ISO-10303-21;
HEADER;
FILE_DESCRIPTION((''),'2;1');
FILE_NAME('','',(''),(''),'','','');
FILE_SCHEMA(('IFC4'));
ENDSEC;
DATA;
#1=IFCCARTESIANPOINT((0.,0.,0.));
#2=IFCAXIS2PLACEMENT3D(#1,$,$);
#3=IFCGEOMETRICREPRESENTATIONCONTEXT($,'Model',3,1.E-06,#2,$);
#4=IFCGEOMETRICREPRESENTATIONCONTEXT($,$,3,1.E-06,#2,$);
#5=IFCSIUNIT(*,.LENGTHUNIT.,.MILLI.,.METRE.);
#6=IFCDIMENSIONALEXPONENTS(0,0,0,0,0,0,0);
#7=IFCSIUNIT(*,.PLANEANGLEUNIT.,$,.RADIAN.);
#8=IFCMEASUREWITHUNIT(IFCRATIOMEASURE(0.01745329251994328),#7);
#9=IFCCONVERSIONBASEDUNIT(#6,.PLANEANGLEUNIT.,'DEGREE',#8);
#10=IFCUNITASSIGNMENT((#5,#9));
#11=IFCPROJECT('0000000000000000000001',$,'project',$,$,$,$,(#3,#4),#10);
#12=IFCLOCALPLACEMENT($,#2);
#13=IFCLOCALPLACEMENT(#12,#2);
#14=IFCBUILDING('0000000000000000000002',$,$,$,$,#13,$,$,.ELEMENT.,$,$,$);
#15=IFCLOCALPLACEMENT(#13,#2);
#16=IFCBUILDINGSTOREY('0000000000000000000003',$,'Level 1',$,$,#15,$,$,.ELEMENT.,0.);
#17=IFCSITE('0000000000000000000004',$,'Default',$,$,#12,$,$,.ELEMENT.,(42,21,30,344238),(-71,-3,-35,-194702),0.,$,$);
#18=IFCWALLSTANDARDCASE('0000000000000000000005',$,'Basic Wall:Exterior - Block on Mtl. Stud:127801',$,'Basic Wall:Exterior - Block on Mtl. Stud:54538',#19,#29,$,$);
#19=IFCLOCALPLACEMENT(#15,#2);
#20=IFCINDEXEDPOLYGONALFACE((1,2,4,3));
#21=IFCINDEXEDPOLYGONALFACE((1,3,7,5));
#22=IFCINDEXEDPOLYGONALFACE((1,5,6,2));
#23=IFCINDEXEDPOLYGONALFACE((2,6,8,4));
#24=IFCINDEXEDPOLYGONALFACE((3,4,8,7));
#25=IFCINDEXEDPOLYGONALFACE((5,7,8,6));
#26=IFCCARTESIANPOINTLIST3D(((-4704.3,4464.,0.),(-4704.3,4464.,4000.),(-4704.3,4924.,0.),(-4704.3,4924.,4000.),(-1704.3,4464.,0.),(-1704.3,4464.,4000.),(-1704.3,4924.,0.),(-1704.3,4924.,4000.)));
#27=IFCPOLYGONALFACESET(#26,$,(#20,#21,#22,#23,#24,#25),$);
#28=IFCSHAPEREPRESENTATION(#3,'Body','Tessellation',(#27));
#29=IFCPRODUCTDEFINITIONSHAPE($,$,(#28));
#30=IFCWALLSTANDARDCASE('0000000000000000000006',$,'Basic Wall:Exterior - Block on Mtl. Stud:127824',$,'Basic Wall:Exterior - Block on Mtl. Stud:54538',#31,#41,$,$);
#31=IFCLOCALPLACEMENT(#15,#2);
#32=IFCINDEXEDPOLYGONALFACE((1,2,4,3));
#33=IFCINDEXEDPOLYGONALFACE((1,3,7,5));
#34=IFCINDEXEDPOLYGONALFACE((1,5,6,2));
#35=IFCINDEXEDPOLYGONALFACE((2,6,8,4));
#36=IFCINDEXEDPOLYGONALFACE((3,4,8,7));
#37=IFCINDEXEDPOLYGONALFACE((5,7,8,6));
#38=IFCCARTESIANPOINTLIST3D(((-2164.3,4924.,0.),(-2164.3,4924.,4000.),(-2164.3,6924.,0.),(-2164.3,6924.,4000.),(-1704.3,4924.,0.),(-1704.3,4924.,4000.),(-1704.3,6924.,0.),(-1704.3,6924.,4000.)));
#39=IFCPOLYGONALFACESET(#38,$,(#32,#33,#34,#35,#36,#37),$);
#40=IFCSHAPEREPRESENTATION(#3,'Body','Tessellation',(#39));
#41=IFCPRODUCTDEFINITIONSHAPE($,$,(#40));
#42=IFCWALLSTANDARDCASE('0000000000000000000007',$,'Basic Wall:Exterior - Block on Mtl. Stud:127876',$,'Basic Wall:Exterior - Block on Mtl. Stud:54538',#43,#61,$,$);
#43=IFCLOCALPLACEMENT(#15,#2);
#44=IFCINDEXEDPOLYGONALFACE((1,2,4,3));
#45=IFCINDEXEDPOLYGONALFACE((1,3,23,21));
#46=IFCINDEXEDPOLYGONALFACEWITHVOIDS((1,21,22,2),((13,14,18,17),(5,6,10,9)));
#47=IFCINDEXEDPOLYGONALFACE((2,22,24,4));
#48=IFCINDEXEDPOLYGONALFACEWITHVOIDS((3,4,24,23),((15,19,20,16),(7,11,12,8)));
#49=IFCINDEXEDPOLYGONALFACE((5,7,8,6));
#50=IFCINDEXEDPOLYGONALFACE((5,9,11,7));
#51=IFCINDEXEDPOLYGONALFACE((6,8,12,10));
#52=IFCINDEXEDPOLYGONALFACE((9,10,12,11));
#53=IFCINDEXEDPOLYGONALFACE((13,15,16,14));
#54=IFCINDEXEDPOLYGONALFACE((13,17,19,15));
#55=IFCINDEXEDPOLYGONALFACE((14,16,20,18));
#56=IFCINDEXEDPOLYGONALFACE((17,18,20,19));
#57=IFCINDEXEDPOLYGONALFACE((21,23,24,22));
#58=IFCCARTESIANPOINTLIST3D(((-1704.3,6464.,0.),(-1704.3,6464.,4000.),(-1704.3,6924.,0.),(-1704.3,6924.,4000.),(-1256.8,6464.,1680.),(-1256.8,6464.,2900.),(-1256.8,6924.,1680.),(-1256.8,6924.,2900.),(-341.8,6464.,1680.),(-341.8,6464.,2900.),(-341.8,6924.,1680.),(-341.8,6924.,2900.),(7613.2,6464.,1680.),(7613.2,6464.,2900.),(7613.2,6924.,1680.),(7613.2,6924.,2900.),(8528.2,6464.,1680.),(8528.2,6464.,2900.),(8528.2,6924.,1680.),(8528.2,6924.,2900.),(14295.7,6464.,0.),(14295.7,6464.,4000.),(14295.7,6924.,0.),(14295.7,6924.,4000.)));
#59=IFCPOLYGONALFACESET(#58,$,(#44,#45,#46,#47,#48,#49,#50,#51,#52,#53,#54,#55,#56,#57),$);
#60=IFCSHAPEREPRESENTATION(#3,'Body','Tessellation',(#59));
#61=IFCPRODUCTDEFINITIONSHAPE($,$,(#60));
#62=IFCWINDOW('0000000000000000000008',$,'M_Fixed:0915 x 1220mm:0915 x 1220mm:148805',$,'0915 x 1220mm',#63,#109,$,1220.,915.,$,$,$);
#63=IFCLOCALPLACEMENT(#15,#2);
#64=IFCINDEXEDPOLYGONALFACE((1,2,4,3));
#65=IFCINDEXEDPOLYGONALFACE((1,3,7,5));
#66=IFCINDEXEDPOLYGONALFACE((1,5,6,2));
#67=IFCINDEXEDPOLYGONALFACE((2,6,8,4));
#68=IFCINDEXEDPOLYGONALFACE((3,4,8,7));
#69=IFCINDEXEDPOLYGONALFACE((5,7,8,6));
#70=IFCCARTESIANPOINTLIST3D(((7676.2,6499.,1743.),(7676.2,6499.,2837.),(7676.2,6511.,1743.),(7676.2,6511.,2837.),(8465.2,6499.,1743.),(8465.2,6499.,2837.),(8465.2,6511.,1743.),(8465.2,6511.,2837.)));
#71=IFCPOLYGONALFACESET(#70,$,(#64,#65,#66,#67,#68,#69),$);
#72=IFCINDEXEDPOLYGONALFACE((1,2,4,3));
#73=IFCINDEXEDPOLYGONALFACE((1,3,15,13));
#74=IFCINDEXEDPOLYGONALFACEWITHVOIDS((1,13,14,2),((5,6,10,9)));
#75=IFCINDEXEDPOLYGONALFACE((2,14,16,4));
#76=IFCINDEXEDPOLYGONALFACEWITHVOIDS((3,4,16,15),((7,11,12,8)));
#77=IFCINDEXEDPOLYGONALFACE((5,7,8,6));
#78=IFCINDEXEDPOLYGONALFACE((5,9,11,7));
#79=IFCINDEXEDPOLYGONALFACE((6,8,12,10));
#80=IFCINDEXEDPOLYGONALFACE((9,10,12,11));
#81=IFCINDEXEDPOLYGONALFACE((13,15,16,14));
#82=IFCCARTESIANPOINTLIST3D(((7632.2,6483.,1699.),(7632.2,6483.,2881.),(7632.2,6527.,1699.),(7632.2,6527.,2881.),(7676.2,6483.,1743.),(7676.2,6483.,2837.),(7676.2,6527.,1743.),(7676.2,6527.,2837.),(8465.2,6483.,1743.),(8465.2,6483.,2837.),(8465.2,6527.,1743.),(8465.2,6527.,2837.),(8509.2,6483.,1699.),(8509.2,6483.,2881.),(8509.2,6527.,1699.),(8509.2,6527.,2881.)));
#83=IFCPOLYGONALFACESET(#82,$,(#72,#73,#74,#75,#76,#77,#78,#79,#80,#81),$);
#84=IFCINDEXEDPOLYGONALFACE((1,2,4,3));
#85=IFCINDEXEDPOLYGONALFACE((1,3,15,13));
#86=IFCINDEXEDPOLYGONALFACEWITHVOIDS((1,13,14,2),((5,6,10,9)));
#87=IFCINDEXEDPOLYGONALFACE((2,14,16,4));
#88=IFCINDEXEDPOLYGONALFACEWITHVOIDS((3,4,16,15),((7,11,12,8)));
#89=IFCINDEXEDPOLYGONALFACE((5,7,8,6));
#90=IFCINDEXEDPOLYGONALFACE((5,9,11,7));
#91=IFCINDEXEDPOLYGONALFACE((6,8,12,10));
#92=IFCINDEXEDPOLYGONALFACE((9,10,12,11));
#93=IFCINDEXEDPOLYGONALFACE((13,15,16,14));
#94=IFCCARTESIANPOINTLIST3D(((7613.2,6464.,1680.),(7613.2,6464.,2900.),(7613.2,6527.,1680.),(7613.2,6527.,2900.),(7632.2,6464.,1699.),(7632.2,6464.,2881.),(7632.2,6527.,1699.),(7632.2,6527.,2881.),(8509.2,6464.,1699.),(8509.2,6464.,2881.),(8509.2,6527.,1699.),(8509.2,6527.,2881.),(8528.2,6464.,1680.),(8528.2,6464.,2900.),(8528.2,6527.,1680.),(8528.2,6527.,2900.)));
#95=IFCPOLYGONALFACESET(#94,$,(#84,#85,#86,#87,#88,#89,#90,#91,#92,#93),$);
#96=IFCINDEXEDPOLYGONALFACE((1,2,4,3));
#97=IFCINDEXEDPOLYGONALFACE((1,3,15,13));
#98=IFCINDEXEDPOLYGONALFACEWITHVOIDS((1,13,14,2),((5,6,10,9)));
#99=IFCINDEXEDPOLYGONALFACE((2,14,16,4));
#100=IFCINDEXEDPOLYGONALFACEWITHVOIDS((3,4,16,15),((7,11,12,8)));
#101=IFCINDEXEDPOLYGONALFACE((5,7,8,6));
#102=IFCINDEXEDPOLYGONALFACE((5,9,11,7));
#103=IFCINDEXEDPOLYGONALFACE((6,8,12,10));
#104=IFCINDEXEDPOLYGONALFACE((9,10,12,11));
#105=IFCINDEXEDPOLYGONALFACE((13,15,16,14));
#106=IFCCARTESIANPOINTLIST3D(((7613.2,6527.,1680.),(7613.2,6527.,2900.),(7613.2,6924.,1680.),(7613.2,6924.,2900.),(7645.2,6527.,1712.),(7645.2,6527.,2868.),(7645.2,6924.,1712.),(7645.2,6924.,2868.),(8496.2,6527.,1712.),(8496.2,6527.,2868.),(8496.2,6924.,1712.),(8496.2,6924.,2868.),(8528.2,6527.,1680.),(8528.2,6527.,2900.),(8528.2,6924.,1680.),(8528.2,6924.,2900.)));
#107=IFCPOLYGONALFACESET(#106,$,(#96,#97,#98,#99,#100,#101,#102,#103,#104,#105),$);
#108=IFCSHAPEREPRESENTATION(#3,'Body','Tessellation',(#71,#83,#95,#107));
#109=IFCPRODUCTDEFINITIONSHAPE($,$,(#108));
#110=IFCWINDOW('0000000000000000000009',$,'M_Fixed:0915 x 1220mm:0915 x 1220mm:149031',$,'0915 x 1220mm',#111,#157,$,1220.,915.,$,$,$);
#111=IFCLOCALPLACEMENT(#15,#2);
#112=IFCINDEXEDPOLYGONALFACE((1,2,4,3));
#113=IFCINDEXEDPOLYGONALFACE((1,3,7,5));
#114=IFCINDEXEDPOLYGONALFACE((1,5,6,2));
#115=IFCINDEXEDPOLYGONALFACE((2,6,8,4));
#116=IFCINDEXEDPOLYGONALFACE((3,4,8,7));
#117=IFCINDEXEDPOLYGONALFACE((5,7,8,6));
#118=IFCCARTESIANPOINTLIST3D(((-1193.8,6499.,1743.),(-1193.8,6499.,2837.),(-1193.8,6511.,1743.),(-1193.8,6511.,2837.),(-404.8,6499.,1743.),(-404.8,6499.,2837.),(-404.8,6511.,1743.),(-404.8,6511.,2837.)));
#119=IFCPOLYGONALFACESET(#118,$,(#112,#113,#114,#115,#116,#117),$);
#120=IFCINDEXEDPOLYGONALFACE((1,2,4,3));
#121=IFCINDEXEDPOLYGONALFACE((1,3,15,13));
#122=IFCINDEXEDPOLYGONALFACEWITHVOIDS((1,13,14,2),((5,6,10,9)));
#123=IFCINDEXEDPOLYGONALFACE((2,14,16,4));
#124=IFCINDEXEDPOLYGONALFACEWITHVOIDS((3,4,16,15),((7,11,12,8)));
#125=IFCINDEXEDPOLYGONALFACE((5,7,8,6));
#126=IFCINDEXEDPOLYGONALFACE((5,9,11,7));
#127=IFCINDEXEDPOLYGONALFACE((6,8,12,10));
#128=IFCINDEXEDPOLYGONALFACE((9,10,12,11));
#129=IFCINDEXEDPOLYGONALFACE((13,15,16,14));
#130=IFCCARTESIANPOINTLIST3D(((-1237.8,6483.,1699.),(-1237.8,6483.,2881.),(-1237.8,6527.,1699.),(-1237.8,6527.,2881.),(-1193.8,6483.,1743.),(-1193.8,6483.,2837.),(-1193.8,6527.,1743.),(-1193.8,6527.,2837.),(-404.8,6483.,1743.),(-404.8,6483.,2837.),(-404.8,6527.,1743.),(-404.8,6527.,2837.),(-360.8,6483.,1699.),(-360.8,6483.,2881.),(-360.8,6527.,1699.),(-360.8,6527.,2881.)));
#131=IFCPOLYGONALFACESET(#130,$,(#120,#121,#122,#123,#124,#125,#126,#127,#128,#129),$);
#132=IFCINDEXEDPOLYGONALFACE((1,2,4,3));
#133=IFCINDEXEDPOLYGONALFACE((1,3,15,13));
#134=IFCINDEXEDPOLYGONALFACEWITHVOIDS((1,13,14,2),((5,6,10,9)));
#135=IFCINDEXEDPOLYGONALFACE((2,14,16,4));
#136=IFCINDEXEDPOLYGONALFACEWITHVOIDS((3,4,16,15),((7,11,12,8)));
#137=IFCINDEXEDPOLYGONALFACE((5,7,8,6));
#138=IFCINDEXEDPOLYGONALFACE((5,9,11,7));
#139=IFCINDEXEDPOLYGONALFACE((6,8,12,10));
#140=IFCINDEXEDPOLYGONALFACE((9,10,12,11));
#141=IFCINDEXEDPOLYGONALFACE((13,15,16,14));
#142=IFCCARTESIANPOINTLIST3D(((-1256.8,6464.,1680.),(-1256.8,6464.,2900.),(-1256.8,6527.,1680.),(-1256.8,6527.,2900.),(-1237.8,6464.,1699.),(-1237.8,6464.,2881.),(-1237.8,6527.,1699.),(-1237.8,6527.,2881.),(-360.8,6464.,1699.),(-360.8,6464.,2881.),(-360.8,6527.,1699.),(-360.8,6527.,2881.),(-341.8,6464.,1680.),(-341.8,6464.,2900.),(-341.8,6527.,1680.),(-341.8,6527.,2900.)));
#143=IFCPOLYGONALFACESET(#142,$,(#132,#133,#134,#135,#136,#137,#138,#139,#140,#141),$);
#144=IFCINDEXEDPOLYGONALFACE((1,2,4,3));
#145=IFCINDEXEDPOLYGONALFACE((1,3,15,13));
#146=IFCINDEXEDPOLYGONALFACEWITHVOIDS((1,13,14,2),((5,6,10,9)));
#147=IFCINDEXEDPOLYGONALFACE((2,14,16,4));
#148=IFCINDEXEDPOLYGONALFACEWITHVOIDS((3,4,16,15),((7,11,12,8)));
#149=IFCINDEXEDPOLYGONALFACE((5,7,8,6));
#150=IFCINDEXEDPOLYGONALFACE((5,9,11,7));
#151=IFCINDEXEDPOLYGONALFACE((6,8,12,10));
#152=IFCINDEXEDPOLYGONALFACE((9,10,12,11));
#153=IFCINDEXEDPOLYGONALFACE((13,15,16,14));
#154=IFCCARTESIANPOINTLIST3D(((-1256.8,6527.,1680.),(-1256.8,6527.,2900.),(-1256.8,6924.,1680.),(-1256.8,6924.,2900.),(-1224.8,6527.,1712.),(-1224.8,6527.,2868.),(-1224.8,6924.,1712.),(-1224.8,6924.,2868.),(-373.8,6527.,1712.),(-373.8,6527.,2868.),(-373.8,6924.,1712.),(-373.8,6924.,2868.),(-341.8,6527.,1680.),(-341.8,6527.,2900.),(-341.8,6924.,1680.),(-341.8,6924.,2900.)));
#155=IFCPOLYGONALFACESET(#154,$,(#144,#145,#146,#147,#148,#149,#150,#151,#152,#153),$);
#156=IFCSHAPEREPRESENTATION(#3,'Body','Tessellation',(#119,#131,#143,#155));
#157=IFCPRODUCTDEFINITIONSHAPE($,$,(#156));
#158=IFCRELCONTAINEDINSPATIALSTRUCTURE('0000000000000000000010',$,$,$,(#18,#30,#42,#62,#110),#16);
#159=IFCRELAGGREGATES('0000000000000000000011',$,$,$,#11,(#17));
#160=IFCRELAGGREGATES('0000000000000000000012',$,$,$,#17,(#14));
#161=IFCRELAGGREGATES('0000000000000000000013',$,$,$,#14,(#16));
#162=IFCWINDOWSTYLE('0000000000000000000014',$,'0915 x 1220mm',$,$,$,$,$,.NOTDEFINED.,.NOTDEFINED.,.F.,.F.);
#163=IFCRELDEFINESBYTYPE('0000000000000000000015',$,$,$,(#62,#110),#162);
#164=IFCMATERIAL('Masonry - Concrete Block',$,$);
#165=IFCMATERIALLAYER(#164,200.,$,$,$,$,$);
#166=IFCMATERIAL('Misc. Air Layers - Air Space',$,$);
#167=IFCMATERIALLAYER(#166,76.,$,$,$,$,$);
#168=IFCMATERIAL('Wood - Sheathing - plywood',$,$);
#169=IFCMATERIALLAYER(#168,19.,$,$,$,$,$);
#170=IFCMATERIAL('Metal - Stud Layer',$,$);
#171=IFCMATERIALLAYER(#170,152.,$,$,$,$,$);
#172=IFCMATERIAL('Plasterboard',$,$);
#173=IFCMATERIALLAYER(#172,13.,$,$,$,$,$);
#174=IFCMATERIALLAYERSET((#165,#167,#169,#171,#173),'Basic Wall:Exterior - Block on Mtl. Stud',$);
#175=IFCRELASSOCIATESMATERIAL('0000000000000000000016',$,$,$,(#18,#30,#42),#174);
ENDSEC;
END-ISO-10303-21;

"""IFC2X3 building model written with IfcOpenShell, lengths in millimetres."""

from ifc_helpers import new_model, entity, si_unit, converted_unit, frame, frame_2d, origin, origin_2d_with_axis, place, context, project, spatial, polyline, rectangle, outline, extrude, source, transform, mapped, material, layer, layer_set, layer_usage, type_object, type_shapes, element, fill, save


model = new_model("IFC2X3")

# Units and contexts
model_context = context("Model", 3, precision=1e-06, world=origin())
context_of_model = context(None, 3, precision=1e-06, world=origin())
ifc_project = project(units=[si_unit("LENGTHUNIT", "METRE", prefix="MILLI"), converted_unit("PLANEANGLEUNIT", "DEGREE", entity("IfcRatioMeasure", 0.01745329251994328), si_unit("PLANEANGLEUNIT", "RADIAN"), dimensions=[0, 0, 0, 0, 0, 0, 0])], contexts=[model_context, context_of_model])

# Site, building, storey
site_placement = place(None, origin())
site = spatial("IfcSite", under=ifc_project, at=site_placement, Name="Default", CompositionType="ELEMENT", RefLatitude=(42, 21, 30, 344238), RefLongitude=(-71, -3, -35, -194702), RefElevation=0.0)
building_placement = place(site_placement, origin())
building = spatial("IfcBuilding", under=site, at=building_placement, CompositionType="ELEMENT")
storey_placement = place(building_placement, origin())
storey = spatial("IfcBuildingStorey", under=building, at=storey_placement, Name="Level 1", CompositionType="ELEMENT", Elevation=0.0)

# Walls
ifc_material_1 = material(Name="Masonry - Concrete Block")
ifc_layer_1 = layer(ifc_material_1, 200.0)
ifc_material_2 = material(Name="Misc. Air Layers - Air Space")
ifc_layer_2 = layer(ifc_material_2, 76.0)
ifc_material_3 = material(Name="Wood - Sheathing - plywood")
ifc_layer_3 = layer(ifc_material_3, 19.0)
ifc_material_4 = material(Name="Metal - Stud Layer")
ifc_layer_4 = layer(ifc_material_4, 152.0)
ifc_material_5 = material(Name="Plasterboard")
ifc_layer_5 = layer(ifc_material_5, 13.0)
ifc_layer_set_1 = layer_set([ifc_layer_1, ifc_layer_2, ifc_layer_3, ifc_layer_4, ifc_layer_5], Name="Basic Wall:Exterior - Block on Mtl. Stud")
ifc_layer_usage_1 = layer_usage(ifc_layer_set_1, "AXIS2", "NEGATIVE", 230.0)
wall_1_placement = place(storey_placement, frame((-4704.3, 4694.0, 0.0)))
element("IfcWallStandardCase", 1, at=wall_1_placement, inside=storey, material=ifc_layer_usage_1, Name="Basic Wall:Exterior - Block on Mtl. Stud:127801", ObjectType="Basic Wall:Exterior - Block on Mtl. Stud:54538", context=model_context, shape_type="SweptSolid", body=[
    extrude(rectangle(XDim=3000.0, YDim=460.0, at=frame_2d((1500.0, 0.0), x_axis=(-1.0, 0.0))), origin(), (0.0, 0.0, 1.0), 4000.0),
])
ifc_layer_usage_2 = layer_usage(ifc_layer_set_1, "AXIS2", "NEGATIVE", 230.0)
wall_2_placement = place(storey_placement, frame((-1934.3, 4924.0, 0.0), z_axis=(0.0, 0.0, 1.0), x_axis=(0.0, 1.0, 0.0)))
element("IfcWallStandardCase", 2, at=wall_2_placement, inside=storey, material=ifc_layer_usage_2, Name="Basic Wall:Exterior - Block on Mtl. Stud:127824", ObjectType="Basic Wall:Exterior - Block on Mtl. Stud:54538", context=model_context, shape_type="SweptSolid", body=[
    extrude(rectangle(XDim=2000.0, YDim=460.0, at=frame_2d((1000.0, 0.0), x_axis=(-1.0, 0.0))), origin(), (0.0, 0.0, 1.0), 4000.0),
])

# Wall, openings, windows
ifc_layer_usage_3 = layer_usage(ifc_layer_set_1, "AXIS2", "NEGATIVE", 230.0)
wall_3_placement = place(storey_placement, frame((-1704.3, 6694.0, 0.0)))
wall_3 = element("IfcWallStandardCase", 3, at=wall_3_placement, inside=storey, material=ifc_layer_usage_3, Name="Basic Wall:Exterior - Block on Mtl. Stud:127876", ObjectType="Basic Wall:Exterior - Block on Mtl. Stud:54538", context=model_context, shape_type="SweptSolid", body=[
    extrude(rectangle(XDim=16000.0, YDim=460.0, at=frame_2d((8000.0, 0.0), x_axis=(-1.0, 0.0))), origin(), (0.0, 0.0, 1.0), 4000.0),
])
opening_1_placement = place(wall_3_placement, frame((9317.5, -230.0, 1680.0)))
opening_1 = element("IfcOpeningElement", 4, at=opening_1_placement, cuts=wall_3, ObjectType="Opening", context=model_context, shape_type="SweptSolid", body=[
    extrude(rectangle(XDim=1220.0, YDim=915.0, at=frame_2d((610.0, 457.5), x_axis=(1.0, 0.0))), frame((0.0, 0.0, 0.0), z_axis=(0.0, 1.0, 0.0), x_axis=(0.0, 0.0, 1.0)), (0.0, 0.0, 1.0), 460.0),
])
opening_2_placement = place(wall_3_placement, frame((447.5, -230.0, 1680.0)))
opening_2 = element("IfcOpeningElement", 5, at=opening_2_placement, cuts=wall_3, ObjectType="Opening", context=model_context, shape_type="SweptSolid", body=[
    extrude(rectangle(XDim=1220.0, YDim=915.0, at=frame_2d((610.0, 457.5), x_axis=(1.0, 0.0))), frame((0.0, 0.0, 0.0), z_axis=(0.0, 1.0, 0.0), x_axis=(0.0, 0.0, 1.0)), (0.0, 0.0, 1.0), 460.0),
])
window_style_1 = type_object("IfcWindowStyle", Name="0915 x 1220mm", ConstructionType="NOTDEFINED", OperationType="NOTDEFINED", ParameterTakesPrecedence=False, Sizeable=False)
shared_shape_1 = source(origin(), model_context, "Body", "SweptSolid", [
    extrude(rectangle(XDim=12.0, YDim=789.0, at=origin_2d_with_axis()), frame((457.5, 419.0, 63.0), z_axis=(0.0, 0.0, 1.0), x_axis=(0.0, -1.0, 0.0)), (0.0, 0.0, 1.0), 1094.0),
    extrude(outline(polyline([(-438.5, -591.0), (438.5, -591.0), (438.5, 591.0), (-438.5, 591.0), (-438.5, -591.0)]), holes=[polyline([(-394.5, -547.0), (-394.5, 547.0), (394.5, 547.0), (394.5, -547.0), (-394.5, -547.0)])]), frame((457.5, 397.0, 610.0), z_axis=(0.0, 1.0, 0.0), x_axis=(1.0, 0.0, 0.0)), (0.0, 0.0, 1.0), 44.0),
    extrude(outline(polyline([(-457.5, -610.0), (457.5, -610.0), (457.5, 610.0), (-457.5, 610.0), (-457.5, -610.0)]), holes=[polyline([(-438.5, -591.0), (-438.5, 591.0), (438.5, 591.0), (438.5, -591.0), (-438.5, -591.0)])]), frame((457.5, 397.0, 610.0), z_axis=(0.0, 1.0, 0.0), x_axis=(1.0, 0.0, 0.0)), (0.0, 0.0, 1.0), 63.0),
    extrude(outline(polyline([(-457.5, -610.0), (457.5, -610.0), (457.5, 610.0), (-457.5, 610.0), (-457.5, -610.0)]), holes=[polyline([(-425.5, -578.0), (-425.5, 578.0), (425.5, 578.0), (425.5, -578.0), (-425.5, -578.0)])]), frame((457.5, 0.0, 610.0), z_axis=(0.0, 1.0, 0.0), x_axis=(1.0, 0.0, 0.0)), (0.0, 0.0, 1.0), 397.0),
])
type_shapes(window_style_1, [shared_shape_1])
window_1_placement = place(opening_1_placement, frame((915.0, 460.0, 0.0), z_axis=(0.0, 0.0, 1.0), x_axis=(-1.0, 0.0, 0.0)))
window_1 = element("IfcWindow", 6, at=window_1_placement, inside=storey, type_object=window_style_1, Name="M_Fixed:0915 x 1220mm:0915 x 1220mm:148805", ObjectType="0915 x 1220mm", OverallHeight=1220.0, OverallWidth=915.0, context=model_context, shape_type="MappedRepresentation", body=[
    mapped(shared_shape_1, transform((0.0, 0.0, 0.0), scale=1.0)),
])
fill(opening_1, window_1)
window_2_placement = place(opening_2_placement, frame((915.0, 460.0, 0.0), z_axis=(0.0, 0.0, 1.0), x_axis=(-1.0, 0.0, 0.0)))
window_2 = element("IfcWindow", 7, at=window_2_placement, inside=storey, type_object=window_style_1, Name="M_Fixed:0915 x 1220mm:0915 x 1220mm:149031", ObjectType="0915 x 1220mm", OverallHeight=1220.0, OverallWidth=915.0, context=model_context, shape_type="MappedRepresentation", body=[
    mapped(shared_shape_1, transform((0.0, 0.0, 0.0), scale=1.0)),
])
fill(opening_2, window_2)

save(model, "model.ifc")
